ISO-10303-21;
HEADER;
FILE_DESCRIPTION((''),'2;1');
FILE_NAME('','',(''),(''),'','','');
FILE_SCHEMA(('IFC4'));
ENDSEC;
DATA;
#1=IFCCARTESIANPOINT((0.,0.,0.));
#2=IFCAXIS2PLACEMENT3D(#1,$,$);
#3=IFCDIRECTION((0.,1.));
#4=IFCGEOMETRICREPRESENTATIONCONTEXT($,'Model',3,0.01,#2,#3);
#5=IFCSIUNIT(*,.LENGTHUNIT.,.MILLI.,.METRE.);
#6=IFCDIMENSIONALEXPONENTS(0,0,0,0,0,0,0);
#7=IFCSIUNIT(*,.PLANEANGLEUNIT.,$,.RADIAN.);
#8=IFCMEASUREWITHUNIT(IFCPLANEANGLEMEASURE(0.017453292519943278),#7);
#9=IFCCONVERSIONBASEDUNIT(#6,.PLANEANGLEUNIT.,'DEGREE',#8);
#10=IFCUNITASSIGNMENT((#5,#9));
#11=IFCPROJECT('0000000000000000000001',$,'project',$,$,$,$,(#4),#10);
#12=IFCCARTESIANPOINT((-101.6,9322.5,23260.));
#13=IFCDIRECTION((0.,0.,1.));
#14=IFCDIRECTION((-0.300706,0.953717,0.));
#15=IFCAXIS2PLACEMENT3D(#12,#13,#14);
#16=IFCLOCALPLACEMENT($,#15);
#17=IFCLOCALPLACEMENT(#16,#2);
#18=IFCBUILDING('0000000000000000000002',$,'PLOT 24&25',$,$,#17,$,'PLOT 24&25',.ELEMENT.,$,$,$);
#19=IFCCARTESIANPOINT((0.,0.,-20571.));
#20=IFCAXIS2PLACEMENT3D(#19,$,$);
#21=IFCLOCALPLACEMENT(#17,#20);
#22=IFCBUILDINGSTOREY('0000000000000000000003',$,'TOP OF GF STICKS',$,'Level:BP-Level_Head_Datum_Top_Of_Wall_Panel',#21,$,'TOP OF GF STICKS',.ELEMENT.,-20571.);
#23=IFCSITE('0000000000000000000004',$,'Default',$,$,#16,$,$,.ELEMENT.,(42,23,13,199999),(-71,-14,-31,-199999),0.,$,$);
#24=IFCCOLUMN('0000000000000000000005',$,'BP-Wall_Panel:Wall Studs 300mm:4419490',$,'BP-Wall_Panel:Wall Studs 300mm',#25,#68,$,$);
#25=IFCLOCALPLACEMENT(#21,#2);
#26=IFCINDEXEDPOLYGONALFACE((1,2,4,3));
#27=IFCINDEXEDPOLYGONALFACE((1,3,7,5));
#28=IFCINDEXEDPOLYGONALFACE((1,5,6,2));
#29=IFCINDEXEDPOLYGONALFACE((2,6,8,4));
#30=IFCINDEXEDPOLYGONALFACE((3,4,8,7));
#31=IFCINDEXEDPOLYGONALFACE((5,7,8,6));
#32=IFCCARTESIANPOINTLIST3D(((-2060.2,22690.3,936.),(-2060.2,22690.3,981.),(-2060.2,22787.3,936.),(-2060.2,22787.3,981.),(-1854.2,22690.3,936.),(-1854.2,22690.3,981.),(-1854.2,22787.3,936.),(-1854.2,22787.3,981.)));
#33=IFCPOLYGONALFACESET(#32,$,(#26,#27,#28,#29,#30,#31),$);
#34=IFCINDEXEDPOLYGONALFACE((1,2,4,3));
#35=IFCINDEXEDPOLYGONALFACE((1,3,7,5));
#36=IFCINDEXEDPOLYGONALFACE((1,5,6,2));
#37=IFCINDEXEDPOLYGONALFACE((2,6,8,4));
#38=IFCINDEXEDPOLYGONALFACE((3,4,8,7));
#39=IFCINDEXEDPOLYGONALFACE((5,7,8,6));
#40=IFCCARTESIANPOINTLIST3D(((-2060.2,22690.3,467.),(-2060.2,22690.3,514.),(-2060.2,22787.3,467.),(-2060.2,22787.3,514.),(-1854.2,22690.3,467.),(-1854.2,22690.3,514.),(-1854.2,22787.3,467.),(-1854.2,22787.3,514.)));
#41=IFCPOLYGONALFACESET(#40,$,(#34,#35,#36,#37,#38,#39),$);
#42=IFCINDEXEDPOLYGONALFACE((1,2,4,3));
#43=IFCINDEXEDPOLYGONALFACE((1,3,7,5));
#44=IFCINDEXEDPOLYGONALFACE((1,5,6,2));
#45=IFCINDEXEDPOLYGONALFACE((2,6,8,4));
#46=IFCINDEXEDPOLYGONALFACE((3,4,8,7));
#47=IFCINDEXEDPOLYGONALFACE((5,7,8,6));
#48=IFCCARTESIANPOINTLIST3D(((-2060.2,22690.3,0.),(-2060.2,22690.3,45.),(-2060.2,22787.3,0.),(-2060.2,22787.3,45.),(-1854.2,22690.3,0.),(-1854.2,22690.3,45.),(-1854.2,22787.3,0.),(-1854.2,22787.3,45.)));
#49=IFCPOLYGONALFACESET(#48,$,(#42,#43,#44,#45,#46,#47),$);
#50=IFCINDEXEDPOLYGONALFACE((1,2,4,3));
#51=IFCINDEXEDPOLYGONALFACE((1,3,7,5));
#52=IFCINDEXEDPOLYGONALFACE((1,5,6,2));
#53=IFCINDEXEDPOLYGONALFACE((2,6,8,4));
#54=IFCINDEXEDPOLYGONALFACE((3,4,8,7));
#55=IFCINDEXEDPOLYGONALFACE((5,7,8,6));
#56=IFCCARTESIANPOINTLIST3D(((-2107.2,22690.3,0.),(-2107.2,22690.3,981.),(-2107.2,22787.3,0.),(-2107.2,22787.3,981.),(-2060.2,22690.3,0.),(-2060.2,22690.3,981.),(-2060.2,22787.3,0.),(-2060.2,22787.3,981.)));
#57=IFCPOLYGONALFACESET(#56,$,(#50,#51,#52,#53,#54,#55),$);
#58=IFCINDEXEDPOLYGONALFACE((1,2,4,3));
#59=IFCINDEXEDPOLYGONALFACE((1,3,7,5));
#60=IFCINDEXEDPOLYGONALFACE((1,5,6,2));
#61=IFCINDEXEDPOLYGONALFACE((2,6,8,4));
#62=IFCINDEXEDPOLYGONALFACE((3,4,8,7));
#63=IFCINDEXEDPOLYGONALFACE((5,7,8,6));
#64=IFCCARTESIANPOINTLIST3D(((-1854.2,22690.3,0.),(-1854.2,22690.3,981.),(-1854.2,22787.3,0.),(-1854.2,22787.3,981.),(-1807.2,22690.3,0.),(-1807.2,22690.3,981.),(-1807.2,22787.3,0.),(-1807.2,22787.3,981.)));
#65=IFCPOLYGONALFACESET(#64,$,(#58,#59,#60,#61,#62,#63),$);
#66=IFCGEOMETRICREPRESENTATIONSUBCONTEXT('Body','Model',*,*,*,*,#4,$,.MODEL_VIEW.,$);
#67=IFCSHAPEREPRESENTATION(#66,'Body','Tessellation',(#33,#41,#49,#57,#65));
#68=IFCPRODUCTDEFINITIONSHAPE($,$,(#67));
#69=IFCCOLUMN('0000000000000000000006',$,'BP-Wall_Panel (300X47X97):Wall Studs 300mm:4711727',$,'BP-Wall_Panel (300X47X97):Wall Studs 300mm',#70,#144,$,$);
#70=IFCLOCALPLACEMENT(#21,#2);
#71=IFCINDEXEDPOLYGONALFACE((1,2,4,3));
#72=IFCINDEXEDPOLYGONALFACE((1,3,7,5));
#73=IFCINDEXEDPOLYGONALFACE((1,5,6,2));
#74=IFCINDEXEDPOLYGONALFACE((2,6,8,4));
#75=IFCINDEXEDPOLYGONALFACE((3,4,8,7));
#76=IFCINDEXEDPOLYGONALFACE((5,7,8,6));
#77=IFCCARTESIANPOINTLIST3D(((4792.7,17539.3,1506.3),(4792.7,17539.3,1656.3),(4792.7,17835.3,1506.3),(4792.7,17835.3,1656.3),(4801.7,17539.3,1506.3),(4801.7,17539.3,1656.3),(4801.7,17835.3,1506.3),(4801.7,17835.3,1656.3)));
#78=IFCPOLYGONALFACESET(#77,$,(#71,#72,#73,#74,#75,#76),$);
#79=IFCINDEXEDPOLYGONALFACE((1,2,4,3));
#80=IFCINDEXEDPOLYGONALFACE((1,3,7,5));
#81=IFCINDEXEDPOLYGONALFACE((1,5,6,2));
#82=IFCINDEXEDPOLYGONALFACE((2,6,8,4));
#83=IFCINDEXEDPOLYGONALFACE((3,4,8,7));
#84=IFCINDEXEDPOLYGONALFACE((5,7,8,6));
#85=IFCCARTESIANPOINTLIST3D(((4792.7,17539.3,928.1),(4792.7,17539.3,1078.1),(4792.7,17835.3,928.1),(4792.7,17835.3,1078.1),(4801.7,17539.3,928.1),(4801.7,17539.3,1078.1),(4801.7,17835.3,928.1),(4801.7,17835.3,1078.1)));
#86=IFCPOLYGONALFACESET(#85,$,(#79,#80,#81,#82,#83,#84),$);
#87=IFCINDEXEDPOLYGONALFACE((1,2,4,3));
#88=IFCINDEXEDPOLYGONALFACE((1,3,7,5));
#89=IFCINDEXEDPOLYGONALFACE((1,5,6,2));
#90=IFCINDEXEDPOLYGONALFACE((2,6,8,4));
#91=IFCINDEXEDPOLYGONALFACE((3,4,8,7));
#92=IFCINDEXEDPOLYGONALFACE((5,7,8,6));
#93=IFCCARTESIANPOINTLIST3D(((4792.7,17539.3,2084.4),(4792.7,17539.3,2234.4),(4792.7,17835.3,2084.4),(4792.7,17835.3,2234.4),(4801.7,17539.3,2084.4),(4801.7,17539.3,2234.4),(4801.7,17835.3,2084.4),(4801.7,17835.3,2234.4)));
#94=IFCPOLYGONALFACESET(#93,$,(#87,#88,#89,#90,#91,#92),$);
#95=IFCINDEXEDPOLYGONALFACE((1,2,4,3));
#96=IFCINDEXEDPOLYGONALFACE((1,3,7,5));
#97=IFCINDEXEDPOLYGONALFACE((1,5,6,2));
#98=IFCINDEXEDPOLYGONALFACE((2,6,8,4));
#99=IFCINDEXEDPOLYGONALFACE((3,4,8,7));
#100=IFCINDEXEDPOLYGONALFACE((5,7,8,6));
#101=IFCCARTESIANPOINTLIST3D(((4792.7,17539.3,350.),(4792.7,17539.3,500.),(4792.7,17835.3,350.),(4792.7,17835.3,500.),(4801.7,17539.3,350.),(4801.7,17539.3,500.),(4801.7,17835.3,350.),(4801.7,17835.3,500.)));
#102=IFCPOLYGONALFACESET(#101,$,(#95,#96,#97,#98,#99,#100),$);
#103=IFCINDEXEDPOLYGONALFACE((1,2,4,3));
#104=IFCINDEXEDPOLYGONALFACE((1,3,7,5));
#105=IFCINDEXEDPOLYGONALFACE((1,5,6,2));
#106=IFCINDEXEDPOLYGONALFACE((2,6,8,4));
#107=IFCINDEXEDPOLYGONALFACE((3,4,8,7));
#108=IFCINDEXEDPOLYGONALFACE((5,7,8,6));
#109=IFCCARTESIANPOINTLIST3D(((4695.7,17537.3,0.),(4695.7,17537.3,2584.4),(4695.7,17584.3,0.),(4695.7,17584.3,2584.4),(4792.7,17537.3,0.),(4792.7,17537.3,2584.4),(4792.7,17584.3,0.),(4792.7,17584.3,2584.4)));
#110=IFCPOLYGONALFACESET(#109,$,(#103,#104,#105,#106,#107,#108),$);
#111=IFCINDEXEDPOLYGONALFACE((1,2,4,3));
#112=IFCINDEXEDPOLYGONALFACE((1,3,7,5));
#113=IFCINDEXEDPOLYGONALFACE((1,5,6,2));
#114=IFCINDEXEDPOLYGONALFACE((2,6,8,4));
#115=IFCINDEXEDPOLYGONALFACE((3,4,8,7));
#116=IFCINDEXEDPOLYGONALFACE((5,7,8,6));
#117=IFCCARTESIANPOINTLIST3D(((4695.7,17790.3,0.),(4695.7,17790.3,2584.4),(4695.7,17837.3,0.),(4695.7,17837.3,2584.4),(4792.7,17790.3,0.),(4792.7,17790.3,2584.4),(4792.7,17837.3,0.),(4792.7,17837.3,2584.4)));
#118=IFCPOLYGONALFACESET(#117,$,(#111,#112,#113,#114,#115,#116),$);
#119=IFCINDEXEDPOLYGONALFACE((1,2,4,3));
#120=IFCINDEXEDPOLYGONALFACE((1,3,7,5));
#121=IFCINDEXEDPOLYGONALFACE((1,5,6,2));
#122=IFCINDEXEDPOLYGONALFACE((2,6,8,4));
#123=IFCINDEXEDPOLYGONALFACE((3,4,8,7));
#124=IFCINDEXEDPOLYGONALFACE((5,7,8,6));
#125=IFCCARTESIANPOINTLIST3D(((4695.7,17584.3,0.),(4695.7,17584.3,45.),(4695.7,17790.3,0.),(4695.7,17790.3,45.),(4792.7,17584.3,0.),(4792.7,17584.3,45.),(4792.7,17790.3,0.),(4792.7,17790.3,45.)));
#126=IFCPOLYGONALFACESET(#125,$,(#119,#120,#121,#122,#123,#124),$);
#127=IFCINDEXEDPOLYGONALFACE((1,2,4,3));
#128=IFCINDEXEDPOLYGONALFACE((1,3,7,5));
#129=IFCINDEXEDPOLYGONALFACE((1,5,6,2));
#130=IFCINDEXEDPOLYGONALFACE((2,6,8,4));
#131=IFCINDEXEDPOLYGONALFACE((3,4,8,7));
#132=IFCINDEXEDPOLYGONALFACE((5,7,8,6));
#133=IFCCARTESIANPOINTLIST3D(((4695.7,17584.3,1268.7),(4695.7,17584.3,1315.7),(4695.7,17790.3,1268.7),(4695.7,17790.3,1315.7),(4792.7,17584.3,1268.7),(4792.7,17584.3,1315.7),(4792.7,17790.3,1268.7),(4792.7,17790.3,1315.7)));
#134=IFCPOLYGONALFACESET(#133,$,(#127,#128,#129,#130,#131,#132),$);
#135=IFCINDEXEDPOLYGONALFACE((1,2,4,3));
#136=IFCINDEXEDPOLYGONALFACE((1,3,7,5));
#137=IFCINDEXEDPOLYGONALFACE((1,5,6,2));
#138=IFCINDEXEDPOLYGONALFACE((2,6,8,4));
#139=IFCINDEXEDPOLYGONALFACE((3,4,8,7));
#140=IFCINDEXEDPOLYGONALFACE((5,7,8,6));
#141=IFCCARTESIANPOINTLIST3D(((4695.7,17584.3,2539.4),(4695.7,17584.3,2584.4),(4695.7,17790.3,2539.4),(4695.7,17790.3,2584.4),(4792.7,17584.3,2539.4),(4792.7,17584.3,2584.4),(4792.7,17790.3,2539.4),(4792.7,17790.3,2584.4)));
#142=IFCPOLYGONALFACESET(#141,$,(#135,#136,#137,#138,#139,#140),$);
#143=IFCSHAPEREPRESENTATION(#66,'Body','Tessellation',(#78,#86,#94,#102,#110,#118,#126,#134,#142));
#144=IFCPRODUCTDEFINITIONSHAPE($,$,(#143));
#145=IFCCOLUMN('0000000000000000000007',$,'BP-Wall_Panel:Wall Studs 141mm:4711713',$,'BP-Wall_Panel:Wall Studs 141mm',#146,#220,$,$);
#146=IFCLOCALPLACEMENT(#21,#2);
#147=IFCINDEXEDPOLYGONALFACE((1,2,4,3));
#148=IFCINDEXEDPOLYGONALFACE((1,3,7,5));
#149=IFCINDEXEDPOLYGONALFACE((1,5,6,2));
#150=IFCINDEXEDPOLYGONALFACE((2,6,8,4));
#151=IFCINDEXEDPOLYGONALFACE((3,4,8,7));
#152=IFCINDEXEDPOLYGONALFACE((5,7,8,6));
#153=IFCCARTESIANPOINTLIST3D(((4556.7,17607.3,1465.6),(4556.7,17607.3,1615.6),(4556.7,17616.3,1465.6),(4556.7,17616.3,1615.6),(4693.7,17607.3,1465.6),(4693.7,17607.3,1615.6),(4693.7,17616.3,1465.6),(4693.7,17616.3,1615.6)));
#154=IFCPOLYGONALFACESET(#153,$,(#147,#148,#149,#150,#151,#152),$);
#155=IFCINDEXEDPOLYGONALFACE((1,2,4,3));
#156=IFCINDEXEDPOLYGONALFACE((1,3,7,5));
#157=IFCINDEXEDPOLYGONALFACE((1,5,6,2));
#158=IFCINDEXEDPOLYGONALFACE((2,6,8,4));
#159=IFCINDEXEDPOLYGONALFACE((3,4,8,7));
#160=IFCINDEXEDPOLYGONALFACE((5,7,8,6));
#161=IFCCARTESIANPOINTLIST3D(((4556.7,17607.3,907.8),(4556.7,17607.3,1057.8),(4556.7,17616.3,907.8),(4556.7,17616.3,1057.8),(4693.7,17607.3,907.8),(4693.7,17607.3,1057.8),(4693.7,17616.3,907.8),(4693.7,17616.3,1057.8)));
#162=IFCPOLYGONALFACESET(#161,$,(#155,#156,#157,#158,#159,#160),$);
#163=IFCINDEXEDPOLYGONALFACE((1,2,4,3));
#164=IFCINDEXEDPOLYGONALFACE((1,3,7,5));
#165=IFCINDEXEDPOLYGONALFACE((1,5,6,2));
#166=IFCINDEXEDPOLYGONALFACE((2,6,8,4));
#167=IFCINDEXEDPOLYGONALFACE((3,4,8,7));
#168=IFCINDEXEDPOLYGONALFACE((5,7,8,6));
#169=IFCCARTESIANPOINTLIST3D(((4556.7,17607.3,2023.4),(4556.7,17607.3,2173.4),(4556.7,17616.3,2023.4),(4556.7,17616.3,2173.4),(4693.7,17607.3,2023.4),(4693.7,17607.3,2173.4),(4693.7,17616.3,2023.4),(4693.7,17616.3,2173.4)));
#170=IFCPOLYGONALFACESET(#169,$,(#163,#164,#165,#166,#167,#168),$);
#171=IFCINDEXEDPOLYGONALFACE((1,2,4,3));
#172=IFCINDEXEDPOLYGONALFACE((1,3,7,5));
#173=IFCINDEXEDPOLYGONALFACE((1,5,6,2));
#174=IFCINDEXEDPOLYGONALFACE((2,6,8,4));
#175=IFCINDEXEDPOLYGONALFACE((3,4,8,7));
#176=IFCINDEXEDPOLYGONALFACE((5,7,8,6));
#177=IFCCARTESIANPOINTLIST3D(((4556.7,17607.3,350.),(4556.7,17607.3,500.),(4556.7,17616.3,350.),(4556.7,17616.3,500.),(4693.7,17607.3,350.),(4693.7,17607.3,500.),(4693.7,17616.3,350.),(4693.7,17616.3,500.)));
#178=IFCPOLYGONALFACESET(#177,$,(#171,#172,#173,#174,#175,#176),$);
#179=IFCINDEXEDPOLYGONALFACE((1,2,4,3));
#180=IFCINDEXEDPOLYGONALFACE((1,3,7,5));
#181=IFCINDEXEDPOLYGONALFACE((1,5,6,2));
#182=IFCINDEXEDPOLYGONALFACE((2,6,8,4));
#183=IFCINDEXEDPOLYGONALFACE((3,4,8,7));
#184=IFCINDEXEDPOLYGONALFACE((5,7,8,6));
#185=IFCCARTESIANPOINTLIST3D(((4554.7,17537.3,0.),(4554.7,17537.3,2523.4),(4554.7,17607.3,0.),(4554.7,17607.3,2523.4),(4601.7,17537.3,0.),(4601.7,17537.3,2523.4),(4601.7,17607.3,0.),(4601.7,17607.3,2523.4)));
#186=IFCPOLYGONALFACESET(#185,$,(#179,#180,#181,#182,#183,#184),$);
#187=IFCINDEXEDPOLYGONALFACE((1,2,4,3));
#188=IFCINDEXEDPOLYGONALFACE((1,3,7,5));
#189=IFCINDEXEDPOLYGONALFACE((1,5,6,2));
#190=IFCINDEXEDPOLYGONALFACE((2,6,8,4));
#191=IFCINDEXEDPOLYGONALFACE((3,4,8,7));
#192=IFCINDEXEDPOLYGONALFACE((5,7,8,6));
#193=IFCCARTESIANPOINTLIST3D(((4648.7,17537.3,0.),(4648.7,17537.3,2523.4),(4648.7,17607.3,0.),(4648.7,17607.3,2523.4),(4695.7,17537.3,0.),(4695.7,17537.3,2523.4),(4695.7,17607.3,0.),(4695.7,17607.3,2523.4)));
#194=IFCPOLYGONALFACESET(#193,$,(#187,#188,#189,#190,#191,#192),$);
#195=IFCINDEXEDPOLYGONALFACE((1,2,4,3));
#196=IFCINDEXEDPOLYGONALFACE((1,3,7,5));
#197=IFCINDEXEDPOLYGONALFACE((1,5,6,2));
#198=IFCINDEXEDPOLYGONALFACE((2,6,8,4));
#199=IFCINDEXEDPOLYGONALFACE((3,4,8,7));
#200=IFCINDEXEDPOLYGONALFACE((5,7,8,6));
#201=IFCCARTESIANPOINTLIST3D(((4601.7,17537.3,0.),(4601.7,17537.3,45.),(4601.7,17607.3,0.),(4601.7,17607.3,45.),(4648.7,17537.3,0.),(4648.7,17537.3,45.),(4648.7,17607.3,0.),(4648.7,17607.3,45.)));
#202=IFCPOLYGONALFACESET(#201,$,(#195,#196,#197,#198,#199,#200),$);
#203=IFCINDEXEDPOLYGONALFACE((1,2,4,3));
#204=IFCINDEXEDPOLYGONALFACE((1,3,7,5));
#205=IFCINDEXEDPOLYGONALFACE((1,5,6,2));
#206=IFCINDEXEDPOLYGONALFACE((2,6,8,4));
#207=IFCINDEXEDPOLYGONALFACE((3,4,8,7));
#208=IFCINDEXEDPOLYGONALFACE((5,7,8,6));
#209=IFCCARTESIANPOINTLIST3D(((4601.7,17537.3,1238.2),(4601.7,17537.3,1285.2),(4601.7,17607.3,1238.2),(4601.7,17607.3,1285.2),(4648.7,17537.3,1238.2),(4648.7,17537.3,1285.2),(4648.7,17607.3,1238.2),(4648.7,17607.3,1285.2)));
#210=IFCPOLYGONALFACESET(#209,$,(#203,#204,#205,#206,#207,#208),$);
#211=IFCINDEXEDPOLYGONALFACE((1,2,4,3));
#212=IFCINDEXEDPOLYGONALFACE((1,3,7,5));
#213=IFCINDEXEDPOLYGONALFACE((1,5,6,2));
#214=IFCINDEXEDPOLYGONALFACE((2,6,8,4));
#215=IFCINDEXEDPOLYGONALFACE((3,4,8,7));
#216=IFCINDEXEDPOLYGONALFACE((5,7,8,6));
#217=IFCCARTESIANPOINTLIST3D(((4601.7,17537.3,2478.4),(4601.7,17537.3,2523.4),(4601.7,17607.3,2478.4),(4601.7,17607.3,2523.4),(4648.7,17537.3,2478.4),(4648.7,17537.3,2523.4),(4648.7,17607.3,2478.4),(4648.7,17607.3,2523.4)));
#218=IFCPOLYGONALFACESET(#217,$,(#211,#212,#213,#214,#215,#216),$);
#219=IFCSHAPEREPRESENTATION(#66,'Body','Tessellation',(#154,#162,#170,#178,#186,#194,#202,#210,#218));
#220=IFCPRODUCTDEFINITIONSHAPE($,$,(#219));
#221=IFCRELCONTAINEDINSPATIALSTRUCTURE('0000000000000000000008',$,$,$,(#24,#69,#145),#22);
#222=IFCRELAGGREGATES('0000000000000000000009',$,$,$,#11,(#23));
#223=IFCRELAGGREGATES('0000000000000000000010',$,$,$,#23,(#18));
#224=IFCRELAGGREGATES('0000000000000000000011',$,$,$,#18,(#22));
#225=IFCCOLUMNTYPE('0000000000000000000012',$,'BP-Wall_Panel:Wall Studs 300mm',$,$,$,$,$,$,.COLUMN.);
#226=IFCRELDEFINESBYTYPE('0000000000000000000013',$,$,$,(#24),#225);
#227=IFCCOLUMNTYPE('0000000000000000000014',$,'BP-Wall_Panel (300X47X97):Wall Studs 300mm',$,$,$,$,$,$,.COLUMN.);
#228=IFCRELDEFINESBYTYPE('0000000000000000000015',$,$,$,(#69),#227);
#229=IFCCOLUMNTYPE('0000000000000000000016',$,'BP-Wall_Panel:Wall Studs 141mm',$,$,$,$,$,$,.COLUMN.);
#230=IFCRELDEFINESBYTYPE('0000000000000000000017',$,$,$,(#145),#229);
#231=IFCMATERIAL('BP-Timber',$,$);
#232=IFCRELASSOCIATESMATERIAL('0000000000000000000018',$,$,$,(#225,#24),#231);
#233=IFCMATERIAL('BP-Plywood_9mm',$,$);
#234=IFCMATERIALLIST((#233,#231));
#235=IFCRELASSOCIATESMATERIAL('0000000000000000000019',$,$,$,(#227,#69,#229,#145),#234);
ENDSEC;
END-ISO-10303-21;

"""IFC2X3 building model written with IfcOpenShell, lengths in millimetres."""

from ifc_helpers import new_model, entity, si_unit, converted_unit, direction, frame, frame_2d, origin, origin_2d_with_axis, place, context, subcontext, project, spatial, rectangle, extrude, source, transform, mapped, material, material_list, type_object, type_shapes, element, save


model = new_model("IFC2X3")

# Units and contexts
model_context = context("Model", 3, precision=0.01, world=origin(), true_north=direction((0.0, 1.0)))
body_context = subcontext(model_context, "Body", "Model", "MODEL_VIEW")
ifc_project = project(units=[si_unit("LENGTHUNIT", "METRE", prefix="MILLI"), converted_unit("PLANEANGLEUNIT", "DEGREE", entity("IfcPlaneAngleMeasure", 0.017453292519943278), si_unit("PLANEANGLEUNIT", "RADIAN"), dimensions=[0, 0, 0, 0, 0, 0, 0])], contexts=[model_context])

# Site, building, storey
site_placement = place(None, frame((-101.6, 9322.5, 23260.0), z_axis=(0.0, 0.0, 1.0), x_axis=(-0.300706, 0.953717, 0.0)))
site = spatial("IfcSite", under=ifc_project, at=site_placement, Name="Default", CompositionType="ELEMENT", RefLatitude=(42, 23, 13, 199999), RefLongitude=(-71, -14, -31, -199999), RefElevation=0.0)
building_placement = place(site_placement, origin())
building = spatial("IfcBuilding", under=site, at=building_placement, Name="PLOT 24&25", LongName="PLOT 24&25", CompositionType="ELEMENT")
storey_placement = place(building_placement, frame((0.0, 0.0, -20571.0)))
storey = spatial("IfcBuildingStorey", under=building, at=storey_placement, Name="TOP OF GF STICKS", ObjectType="Level:BP-Level_Head_Datum_Top_Of_Wall_Panel", LongName="TOP OF GF STICKS", CompositionType="ELEMENT", Elevation=-20571.0)

# Columns
ifc_material_1 = material(Name="BP-Plywood_9mm")
ifc_material_2 = material(Name="BP-Timber")
ifc_material_list = material_list([ifc_material_1, ifc_material_2])
column_type_1 = type_object("IfcColumnType", Name="BP-Wall_Panel:Wall Studs 300mm", PredefinedType="COLUMN", material=ifc_material_2)
shared_shape_1 = source(origin(), body_context, "Body", "SweptSolid", [
    extrude(rectangle(XDim=206.0, YDim=97.0, at=frame_2d((0.0, 0.0), x_axis=(1.0, 0.0))), frame((-1957.2, 22738.8, -19635.0)), (0.0, 0.0, 1.0), 45.0),
    extrude(rectangle(XDim=206.0, YDim=97.0, at=frame_2d((0.0, 0.0), x_axis=(1.0, 0.0))), frame((-1957.2, 22738.8, -20104.0)), (0.0, 0.0, 1.0), 47.0),
    extrude(rectangle(XDim=206.0, YDim=97.0, at=frame_2d((0.0, 0.0), x_axis=(1.0, 0.0))), frame((-1957.2, 22738.8, -20571.0)), (0.0, 0.0, 1.0), 45.0),
    extrude(rectangle(XDim=97.0, YDim=47.0, at=frame_2d((0.0, 0.0), x_axis=(1.0, 0.0))), frame((-2083.7, 22738.8, -20571.0), z_axis=(0.0, 0.0, 1.0), x_axis=(0.0, -1.0, 0.0)), (0.0, 0.0, 1.0), 981.0),
    extrude(rectangle(XDim=97.0, YDim=47.0, at=frame_2d((0.0, 0.0), x_axis=(1.0, 0.0))), frame((-1830.7, 22738.8, -20571.0), z_axis=(0.0, 0.0, 1.0), x_axis=(0.0, -1.0, 0.0)), (0.0, 0.0, 1.0), 981.0),
])
type_shapes(column_type_1, [shared_shape_1])
column_1_placement = place(storey_placement, frame((0.0, 0.0, 20571.0)))
element("IfcColumn", 1, at=column_1_placement, inside=storey, type_object=column_type_1, material=ifc_material_2, Name="BP-Wall_Panel:Wall Studs 300mm:4419490", ObjectType="BP-Wall_Panel:Wall Studs 300mm", context=body_context, shape_type="MappedRepresentation", body=[
    mapped(shared_shape_1, transform((0.0, 0.0, 0.0), scale=1.0)),
])
column_type_2 = type_object("IfcColumnType", Name="BP-Wall_Panel (300X47X97):Wall Studs 300mm", PredefinedType="COLUMN", material=ifc_material_list)
shared_shape_2 = source(origin(), body_context, "Body", "SweptSolid", [
    extrude(rectangle(XDim=296.0, YDim=9.0, at=origin_2d_with_axis()), frame((-53.0, 0.0, -19064.7), z_axis=(0.0, 0.0, 1.0), x_axis=(0.0, 1.0, 0.0)), (0.0, 0.0, 1.0), 150.0),
    extrude(rectangle(XDim=296.0, YDim=9.0, at=origin_2d_with_axis()), frame((-53.0, 0.0, -19642.9), z_axis=(0.0, 0.0, 1.0), x_axis=(0.0, 1.0, 0.0)), (0.0, 0.0, 1.0), 150.0),
    extrude(rectangle(XDim=296.0, YDim=9.0, at=origin_2d_with_axis()), frame((-53.0, 0.0, -18486.6), z_axis=(0.0, 0.0, 1.0), x_axis=(0.0, 1.0, 0.0)), (0.0, 0.0, 1.0), 150.0),
    extrude(rectangle(XDim=296.0, YDim=9.0, at=origin_2d_with_axis()), frame((-53.0, 0.0, -20221.0), z_axis=(0.0, 0.0, 1.0), x_axis=(0.0, 1.0, 0.0)), (0.0, 0.0, 1.0), 150.0),
    extrude(rectangle(XDim=47.0, YDim=97.0, at=origin_2d_with_axis()), frame((0.0, 126.5, -20571.0), z_axis=(0.0, 0.0, 1.0), x_axis=(0.0, 1.0, 0.0)), (0.0, 0.0, 1.0), 2584.4),
    extrude(rectangle(XDim=47.0, YDim=97.0, at=frame_2d((0.0, 0.0), x_axis=(1.0, 0.0))), frame((0.0, -126.5, -20571.0), z_axis=(0.0, 0.0, 1.0), x_axis=(0.0, 1.0, 0.0)), (0.0, 0.0, 1.0), 2584.4),
    extrude(rectangle(XDim=97.0, YDim=206.0, at=origin_2d_with_axis()), frame((0.0, 0.0, -20571.0)), (0.0, 0.0, 1.0), 45.0),
    extrude(rectangle(XDim=97.0, YDim=206.0, at=origin_2d_with_axis()), frame((0.0, 0.0, -19302.3)), (0.0, 0.0, 1.0), 47.0),
    extrude(rectangle(XDim=97.0, YDim=206.0, at=origin_2d_with_axis()), frame((0.0, 0.0, -18031.6)), (0.0, 0.0, 1.0), 45.0),
])
type_shapes(column_type_2, [shared_shape_2])
column_2_placement = place(storey_placement, frame((4744.2, 17687.3, 20571.0), z_axis=(0.0, 0.0, 1.0), x_axis=(-1.0, 0.0, 0.0)))
element("IfcColumn", 2, at=column_2_placement, inside=storey, type_object=column_type_2, material=ifc_material_list, Name="BP-Wall_Panel (300X47X97):Wall Studs 300mm:4711727", ObjectType="BP-Wall_Panel (300X47X97):Wall Studs 300mm", context=body_context, shape_type="MappedRepresentation", body=[
    mapped(shared_shape_2, transform((0.0, 0.0, 0.0), scale=1.0)),
])
column_type_3 = type_object("IfcColumnType", Name="BP-Wall_Panel:Wall Studs 141mm", PredefinedType="COLUMN", material=ifc_material_list)
shared_shape_3 = source(origin(), body_context, "Body", "SweptSolid", [
    extrude(rectangle(XDim=9.0, YDim=137.0, at=origin_2d_with_axis()), frame((39.5, 0.0, -19105.4)), (0.0, 0.0, 1.0), 150.0),
    extrude(rectangle(XDim=9.0, YDim=137.0, at=origin_2d_with_axis()), frame((39.5, 0.0, -19663.2)), (0.0, 0.0, 1.0), 150.0),
    extrude(rectangle(XDim=9.0, YDim=137.0, at=frame_2d((0.0, 0.0), x_axis=(1.0, 0.0))), frame((39.5, 0.0, -18547.6)), (0.0, 0.0, 1.0), 150.0),
    extrude(rectangle(XDim=9.0, YDim=137.0, at=origin_2d_with_axis()), frame((39.5, 0.0, -20221.0)), (0.0, 0.0, 1.0), 150.0),
    extrude(rectangle(XDim=47.0, YDim=70.0, at=origin_2d_with_axis()), frame((0.0, 47.0, -20571.0), z_axis=(0.0, 0.0, 1.0), x_axis=(0.0, 1.0, 0.0)), (0.0, 0.0, 1.0), 2523.4),
    extrude(rectangle(XDim=47.0, YDim=70.0, at=origin_2d_with_axis()), frame((0.0, -47.0, -20571.0), z_axis=(0.0, 0.0, 1.0), x_axis=(0.0, 1.0, 0.0)), (0.0, 0.0, 1.0), 2523.4),
    extrude(rectangle(XDim=70.0, YDim=47.0, at=origin_2d_with_axis()), frame((0.0, 0.0, -20571.0)), (0.0, 0.0, 1.0), 45.0),
    extrude(rectangle(XDim=70.0, YDim=47.0, at=origin_2d_with_axis()), frame((0.0, 0.0, -19332.8)), (0.0, 0.0, 1.0), 47.0),
    extrude(rectangle(XDim=70.0, YDim=47.0, at=origin_2d_with_axis()), frame((0.0, 0.0, -18092.6)), (0.0, 0.0, 1.0), 45.0),
])
type_shapes(column_type_3, [shared_shape_3])
column_3_placement = place(storey_placement, frame((4625.2, 17572.3, 20571.0), z_axis=(0.0, 0.0, 1.0), x_axis=(0.0, 1.0, 0.0)))
element("IfcColumn", 3, at=column_3_placement, inside=storey, type_object=column_type_3, material=ifc_material_list, Name="BP-Wall_Panel:Wall Studs 141mm:4711713", ObjectType="BP-Wall_Panel:Wall Studs 141mm", context=body_context, shape_type="MappedRepresentation", body=[
    mapped(shared_shape_3, transform((0.0, 0.0, 0.0), scale=1.0)),
])

save(model, "model.ifc")
